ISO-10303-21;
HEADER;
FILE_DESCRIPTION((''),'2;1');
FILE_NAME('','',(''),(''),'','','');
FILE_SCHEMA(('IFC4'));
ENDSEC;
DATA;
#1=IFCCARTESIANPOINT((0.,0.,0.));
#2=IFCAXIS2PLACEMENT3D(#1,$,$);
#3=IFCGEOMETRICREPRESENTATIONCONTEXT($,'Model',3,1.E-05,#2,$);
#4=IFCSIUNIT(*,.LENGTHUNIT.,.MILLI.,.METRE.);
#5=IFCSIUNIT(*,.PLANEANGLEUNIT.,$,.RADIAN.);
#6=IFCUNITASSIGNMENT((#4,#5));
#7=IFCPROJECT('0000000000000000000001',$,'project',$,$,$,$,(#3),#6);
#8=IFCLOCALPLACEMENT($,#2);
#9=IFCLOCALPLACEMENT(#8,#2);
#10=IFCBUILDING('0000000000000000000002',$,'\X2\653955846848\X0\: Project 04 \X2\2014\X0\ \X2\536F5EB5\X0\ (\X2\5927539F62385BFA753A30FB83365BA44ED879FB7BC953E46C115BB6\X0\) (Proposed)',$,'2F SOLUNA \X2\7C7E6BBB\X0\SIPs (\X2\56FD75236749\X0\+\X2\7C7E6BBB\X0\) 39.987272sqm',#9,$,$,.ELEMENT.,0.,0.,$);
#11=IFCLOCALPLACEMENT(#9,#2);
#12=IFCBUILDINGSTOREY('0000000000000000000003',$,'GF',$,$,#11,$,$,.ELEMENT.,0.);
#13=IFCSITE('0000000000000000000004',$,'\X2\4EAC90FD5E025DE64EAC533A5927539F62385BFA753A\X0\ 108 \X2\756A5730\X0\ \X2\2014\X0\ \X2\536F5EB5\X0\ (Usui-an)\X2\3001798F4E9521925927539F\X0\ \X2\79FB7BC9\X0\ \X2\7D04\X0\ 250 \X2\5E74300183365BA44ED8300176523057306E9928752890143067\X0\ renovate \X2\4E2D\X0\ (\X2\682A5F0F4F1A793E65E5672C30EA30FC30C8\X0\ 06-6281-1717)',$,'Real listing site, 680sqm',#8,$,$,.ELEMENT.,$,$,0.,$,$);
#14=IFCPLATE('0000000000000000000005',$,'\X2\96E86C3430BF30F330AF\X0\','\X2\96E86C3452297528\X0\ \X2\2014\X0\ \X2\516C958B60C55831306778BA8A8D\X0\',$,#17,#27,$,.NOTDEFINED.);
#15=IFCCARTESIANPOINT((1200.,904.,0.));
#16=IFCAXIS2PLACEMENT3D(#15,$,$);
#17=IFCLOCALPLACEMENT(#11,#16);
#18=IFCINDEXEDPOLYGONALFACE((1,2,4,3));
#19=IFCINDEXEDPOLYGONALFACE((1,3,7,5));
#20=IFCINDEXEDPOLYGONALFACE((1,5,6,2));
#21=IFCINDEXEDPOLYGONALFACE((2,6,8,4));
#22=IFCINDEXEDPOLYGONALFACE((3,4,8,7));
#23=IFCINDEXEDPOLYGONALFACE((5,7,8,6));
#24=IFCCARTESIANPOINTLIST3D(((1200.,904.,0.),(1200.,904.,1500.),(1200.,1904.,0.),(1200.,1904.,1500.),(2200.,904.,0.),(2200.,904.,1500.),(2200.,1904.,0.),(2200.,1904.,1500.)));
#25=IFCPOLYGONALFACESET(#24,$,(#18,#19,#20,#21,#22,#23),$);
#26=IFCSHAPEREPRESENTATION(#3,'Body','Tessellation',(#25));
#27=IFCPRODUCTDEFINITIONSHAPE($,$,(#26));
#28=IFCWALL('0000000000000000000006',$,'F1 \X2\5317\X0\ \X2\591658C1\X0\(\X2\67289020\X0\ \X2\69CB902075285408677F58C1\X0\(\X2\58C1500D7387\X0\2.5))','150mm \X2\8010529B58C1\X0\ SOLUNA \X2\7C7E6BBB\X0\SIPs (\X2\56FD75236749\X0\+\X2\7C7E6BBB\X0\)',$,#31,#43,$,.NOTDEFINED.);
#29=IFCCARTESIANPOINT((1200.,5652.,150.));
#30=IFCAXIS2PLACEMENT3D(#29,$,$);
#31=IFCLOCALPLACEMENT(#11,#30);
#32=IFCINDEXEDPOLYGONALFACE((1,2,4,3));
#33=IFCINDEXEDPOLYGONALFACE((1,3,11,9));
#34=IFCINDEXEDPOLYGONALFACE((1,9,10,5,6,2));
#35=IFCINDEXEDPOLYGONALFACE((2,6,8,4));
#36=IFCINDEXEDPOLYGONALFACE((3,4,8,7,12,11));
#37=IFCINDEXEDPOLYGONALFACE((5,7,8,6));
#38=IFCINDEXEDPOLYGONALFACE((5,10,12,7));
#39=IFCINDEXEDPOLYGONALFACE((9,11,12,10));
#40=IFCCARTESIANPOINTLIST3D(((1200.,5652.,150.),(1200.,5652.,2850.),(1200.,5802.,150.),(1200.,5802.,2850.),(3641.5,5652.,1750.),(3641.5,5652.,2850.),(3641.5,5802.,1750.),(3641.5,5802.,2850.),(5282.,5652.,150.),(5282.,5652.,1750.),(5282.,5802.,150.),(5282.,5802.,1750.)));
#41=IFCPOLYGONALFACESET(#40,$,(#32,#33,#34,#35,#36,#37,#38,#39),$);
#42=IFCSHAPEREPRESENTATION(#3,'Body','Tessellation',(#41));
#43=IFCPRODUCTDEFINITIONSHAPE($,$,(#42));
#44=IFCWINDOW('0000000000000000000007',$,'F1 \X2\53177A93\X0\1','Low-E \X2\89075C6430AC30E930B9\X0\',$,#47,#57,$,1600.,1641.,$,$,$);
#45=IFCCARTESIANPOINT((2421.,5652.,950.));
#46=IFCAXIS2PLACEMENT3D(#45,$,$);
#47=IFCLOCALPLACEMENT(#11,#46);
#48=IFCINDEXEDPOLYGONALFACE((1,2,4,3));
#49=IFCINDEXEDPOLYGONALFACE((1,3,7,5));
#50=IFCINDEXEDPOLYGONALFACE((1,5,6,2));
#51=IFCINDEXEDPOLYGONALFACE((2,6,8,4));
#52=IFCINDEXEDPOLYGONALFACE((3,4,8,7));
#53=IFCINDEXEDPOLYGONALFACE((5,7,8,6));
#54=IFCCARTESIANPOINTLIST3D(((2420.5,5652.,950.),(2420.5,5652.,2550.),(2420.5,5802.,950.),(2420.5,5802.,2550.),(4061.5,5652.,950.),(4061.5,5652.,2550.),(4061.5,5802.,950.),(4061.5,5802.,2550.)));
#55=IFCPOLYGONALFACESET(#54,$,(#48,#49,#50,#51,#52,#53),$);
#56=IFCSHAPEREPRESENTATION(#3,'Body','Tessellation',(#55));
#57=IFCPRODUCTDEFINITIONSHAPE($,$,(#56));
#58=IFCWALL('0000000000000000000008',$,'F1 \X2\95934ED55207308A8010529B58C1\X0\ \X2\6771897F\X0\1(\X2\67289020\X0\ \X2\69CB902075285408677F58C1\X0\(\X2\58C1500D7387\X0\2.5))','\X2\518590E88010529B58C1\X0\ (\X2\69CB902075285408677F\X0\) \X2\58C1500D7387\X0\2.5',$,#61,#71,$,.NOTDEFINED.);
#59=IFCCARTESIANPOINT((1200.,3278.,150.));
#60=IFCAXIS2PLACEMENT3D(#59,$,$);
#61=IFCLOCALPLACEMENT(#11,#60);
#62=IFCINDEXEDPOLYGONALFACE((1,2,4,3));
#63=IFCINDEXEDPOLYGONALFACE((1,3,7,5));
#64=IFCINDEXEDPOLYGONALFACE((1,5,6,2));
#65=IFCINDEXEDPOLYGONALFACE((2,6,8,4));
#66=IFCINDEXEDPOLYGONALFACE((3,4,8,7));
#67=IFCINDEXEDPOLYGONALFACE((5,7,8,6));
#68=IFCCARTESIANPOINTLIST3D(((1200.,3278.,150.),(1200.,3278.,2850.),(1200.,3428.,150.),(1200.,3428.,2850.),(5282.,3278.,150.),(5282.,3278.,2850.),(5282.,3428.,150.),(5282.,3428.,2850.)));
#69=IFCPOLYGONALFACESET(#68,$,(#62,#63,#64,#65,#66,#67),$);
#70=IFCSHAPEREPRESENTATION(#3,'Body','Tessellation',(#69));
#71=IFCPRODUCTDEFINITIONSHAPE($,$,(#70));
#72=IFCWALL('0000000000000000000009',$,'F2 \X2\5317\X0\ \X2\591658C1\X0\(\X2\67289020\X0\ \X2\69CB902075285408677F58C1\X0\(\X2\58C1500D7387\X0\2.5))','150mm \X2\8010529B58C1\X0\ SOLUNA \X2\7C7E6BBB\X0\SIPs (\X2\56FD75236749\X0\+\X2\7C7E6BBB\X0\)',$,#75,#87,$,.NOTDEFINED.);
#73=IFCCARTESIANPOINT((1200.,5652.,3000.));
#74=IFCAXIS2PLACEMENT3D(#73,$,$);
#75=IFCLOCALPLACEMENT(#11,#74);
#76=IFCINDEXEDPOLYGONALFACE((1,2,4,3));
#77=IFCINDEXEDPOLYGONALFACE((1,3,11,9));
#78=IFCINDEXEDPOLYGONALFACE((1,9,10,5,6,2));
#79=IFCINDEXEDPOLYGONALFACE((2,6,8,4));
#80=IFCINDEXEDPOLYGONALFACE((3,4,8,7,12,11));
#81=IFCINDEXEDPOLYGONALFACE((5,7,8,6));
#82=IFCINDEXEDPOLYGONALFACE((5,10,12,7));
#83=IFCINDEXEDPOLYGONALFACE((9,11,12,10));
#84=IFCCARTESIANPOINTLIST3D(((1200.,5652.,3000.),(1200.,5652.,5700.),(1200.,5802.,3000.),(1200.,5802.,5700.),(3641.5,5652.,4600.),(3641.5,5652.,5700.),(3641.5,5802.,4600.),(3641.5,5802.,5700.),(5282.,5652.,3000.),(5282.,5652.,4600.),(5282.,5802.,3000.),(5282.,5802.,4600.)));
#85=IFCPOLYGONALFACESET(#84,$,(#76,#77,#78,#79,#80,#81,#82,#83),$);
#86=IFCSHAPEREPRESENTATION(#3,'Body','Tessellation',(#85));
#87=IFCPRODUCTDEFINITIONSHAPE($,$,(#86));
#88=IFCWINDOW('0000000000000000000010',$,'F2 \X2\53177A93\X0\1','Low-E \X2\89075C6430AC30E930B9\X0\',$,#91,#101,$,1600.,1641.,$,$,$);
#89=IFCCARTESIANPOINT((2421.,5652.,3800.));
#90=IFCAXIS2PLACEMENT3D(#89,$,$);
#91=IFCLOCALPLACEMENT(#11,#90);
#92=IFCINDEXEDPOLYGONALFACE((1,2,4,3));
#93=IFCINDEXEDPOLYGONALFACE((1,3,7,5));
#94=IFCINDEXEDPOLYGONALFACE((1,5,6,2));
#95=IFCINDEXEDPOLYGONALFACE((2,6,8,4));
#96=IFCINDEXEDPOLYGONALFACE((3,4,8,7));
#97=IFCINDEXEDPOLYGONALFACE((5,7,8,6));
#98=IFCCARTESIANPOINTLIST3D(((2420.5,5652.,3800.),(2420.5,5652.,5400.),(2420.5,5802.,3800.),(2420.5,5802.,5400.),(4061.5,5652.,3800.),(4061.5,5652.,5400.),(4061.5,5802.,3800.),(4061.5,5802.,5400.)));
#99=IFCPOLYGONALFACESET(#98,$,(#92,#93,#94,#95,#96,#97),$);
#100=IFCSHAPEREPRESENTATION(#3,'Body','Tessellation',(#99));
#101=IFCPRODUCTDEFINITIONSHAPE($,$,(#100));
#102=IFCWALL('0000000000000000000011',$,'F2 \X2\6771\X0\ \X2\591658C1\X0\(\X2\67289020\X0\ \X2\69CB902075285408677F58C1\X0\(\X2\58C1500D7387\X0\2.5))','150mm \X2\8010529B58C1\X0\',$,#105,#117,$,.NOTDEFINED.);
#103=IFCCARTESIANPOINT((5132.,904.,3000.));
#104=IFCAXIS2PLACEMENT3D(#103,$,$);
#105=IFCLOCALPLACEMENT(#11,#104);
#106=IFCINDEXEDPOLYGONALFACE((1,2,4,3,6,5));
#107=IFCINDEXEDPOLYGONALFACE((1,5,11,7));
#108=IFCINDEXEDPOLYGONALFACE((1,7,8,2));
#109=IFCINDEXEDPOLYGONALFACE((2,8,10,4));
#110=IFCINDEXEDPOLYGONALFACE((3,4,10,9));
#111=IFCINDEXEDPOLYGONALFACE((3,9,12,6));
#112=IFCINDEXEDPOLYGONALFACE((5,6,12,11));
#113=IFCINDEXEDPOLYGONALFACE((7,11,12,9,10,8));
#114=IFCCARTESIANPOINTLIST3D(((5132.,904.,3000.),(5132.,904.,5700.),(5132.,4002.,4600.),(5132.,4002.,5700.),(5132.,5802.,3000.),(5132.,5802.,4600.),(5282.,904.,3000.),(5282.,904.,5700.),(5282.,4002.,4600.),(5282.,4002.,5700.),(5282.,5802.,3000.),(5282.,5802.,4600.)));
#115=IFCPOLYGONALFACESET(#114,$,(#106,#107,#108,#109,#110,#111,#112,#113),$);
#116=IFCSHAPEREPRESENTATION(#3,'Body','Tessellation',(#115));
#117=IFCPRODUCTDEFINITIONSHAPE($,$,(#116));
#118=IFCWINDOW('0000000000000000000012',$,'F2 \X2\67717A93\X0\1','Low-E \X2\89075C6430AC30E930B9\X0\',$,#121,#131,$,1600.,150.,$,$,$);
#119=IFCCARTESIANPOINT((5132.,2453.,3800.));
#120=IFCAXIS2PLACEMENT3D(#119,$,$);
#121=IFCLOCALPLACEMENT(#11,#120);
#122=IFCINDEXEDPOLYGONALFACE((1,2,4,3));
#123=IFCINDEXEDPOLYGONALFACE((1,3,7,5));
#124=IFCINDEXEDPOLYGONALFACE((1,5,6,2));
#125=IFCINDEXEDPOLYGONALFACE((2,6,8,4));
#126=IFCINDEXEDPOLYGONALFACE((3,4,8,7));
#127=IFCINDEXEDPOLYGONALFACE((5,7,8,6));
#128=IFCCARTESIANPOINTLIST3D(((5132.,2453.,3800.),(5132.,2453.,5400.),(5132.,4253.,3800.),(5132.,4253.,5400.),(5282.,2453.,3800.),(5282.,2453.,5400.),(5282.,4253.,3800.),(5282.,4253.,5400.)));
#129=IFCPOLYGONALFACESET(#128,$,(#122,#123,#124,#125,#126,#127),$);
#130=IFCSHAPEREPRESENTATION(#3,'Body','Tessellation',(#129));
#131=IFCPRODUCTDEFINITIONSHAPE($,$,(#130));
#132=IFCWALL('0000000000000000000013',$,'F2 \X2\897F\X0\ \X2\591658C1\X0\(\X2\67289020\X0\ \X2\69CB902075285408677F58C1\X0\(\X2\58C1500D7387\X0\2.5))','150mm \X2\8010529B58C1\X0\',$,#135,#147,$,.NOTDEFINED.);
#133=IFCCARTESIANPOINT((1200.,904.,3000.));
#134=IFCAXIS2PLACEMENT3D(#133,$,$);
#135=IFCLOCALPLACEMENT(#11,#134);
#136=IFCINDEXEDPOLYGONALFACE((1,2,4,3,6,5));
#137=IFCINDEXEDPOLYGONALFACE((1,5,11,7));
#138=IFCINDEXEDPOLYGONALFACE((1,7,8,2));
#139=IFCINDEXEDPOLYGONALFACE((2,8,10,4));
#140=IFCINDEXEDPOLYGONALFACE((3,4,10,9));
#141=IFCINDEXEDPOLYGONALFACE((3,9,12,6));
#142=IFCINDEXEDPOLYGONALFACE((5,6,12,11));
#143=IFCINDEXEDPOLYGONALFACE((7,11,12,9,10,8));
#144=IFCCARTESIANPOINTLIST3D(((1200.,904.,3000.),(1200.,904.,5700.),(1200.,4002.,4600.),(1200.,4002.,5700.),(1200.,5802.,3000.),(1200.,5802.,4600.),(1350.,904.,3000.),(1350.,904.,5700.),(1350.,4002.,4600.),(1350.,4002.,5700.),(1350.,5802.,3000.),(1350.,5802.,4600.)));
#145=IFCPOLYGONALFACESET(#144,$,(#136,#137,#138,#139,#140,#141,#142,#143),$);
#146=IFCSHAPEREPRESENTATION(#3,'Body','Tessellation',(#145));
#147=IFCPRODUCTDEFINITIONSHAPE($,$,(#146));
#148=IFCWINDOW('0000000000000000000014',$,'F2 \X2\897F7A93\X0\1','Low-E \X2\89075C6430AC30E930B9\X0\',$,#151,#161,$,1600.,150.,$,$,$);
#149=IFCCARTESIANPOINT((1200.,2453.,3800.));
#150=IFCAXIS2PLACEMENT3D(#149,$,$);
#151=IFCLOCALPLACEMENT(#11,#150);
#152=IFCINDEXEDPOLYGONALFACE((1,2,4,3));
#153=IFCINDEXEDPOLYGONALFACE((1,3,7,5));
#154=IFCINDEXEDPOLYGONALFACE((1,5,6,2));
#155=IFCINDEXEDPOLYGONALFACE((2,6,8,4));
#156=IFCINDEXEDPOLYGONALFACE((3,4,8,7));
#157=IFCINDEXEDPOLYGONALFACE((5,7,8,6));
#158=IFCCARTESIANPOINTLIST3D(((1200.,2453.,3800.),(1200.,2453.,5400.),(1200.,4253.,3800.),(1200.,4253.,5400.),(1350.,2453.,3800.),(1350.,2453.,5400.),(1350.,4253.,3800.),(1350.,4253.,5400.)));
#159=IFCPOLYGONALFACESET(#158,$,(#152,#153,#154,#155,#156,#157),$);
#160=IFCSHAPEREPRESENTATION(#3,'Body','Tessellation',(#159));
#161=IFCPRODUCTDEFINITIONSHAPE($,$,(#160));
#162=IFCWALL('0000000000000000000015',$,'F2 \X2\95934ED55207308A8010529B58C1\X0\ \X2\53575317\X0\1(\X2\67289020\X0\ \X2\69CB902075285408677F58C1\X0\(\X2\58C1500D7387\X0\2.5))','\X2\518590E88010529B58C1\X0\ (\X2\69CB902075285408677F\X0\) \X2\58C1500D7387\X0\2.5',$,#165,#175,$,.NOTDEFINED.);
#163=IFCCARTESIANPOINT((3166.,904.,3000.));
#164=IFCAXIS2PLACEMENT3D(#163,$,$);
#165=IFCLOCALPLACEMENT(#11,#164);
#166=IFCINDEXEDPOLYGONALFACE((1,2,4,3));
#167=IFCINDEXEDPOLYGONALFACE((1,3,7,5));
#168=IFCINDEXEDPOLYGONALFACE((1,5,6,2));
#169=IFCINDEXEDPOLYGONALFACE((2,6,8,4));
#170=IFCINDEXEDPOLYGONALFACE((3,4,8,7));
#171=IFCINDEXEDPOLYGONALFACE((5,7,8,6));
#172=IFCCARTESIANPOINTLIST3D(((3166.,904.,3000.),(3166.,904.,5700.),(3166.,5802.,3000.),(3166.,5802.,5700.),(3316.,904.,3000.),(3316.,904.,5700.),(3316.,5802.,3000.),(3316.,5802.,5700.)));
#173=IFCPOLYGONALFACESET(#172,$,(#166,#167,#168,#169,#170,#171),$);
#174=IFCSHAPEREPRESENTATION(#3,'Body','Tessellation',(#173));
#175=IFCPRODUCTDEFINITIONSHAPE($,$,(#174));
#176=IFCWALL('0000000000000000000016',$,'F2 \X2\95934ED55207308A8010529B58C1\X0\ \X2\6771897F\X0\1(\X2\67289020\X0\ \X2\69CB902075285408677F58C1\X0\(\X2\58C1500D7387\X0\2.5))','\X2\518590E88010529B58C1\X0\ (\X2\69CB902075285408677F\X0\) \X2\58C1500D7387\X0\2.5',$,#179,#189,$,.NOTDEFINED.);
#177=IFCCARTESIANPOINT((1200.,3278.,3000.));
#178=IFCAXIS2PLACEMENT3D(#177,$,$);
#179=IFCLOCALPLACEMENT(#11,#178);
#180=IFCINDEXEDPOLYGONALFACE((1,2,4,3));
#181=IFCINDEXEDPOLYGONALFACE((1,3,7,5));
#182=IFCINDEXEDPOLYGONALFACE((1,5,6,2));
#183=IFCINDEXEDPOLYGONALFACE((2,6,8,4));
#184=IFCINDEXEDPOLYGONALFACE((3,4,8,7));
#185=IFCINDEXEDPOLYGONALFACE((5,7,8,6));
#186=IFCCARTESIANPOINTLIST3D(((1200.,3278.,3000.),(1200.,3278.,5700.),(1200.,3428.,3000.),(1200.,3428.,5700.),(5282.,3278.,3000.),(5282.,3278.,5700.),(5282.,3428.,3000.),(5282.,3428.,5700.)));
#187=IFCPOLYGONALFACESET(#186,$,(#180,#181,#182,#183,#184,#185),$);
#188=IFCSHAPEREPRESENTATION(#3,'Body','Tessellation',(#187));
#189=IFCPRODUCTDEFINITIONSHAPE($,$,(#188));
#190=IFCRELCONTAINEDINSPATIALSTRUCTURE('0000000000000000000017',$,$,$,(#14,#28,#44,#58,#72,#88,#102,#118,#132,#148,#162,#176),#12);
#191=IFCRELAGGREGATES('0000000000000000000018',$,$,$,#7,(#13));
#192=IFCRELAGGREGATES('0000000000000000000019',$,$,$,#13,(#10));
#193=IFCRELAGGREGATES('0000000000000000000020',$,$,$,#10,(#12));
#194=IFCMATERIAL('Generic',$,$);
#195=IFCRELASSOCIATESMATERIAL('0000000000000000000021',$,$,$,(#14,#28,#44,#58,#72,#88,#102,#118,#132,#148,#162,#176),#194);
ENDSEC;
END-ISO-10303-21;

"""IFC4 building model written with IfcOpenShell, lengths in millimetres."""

from ifc_helpers import new_model, si_unit, frame, frame_2d, origin, place, context, project, spatial, rectangle, extrude, material, element, fill, save


model = new_model("IFC4")

# Units and contexts
model_context = context("Model", 3, precision=1e-05, world=origin())
ifc_project = project(units=[si_unit("LENGTHUNIT", "METRE", prefix="MILLI"), si_unit("PLANEANGLEUNIT", "RADIAN")], contexts=[model_context])

# Site, building, storey
site_placement = place(None, origin())
site = spatial("IfcSite", under=ifc_project, at=site_placement, Name="京都市左京区大原戸寺町 108 番地 — 卯庵 (Usui-an)、福井→大原 移築 約 250 年、茶室付、癒しの館用途で renovate 中 (株式会社日本リート 06-6281-1717)", ObjectType="Real listing site, 680sqm", CompositionType="ELEMENT", RefElevation=0.0)
building_placement = place(site_placement, origin())
building = spatial("IfcBuilding", under=site, at=building_placement, Name="改善案: Project 04 — 卯庵 (大原戸寺町・茶室付移築古民家) (Proposed)", ObjectType="2F SOLUNA 籾殻SIPs (国産杉+籾殻) 39.987272sqm", CompositionType="ELEMENT", ElevationOfRefHeight=0.0, ElevationOfTerrain=0.0)
storey_placement = place(building_placement, origin())
storey = spatial("IfcBuildingStorey", under=building, at=storey_placement, Name="GF", CompositionType="ELEMENT", Elevation=0.0)

# Plate
ifc_material_1 = material(Name="Generic")
plate_placement = place(storey_placement, frame((1200.0, 904.0, 0.0)))
element("IfcPlate", 1, at=plate_placement, inside=storey, material=ifc_material_1, Name="雨水タンク", Description="雨水利用 — 公開情報で確認", PredefinedType="NOTDEFINED", context=model_context, shape_type="SweptSolid", body=[
    extrude(rectangle(XDim=1000.0, YDim=1000.0, at=frame_2d((500.0, 500.0))), frame((1200.0, 904.0, 0.0)), (0.0, 0.0, 1.0), 1500.0),
])

# Wall, opening, window
wall_1_placement = place(storey_placement, frame((1200.0, 5652.0, 150.0)))
wall_1 = element("IfcWall", 2, at=wall_1_placement, inside=storey, material=ifc_material_1, Name="F1 北 外壁(木造 構造用合板壁(壁倍率2.5))", Description="150mm 耐力壁 SOLUNA 籾殻SIPs (国産杉+籾殻)", PredefinedType="NOTDEFINED", context=model_context, shape_type="SweptSolid", body=[
    extrude(rectangle(XDim=4082.0, YDim=150.0, at=frame_2d((2041.0, 75.0))), frame((1200.0, 5652.0, 150.0)), (0.0, 0.0, 1.0), 2700.0),
])
opening_1_placement = place(storey_placement, frame((2421.0, 5652.0, 950.0)))
opening_1 = element("IfcOpeningElement", 3, at=opening_1_placement, cuts=wall_1, PredefinedType="NOTDEFINED", context=model_context, shape_type="SweptSolid", body=[
    extrude(rectangle(XDim=1641.0, YDim=150.0, at=frame_2d((820.0, 75.0))), frame((2421.0, 5652.0, 950.0)), (0.0, 0.0, 1.0), 1600.0),
])
window_1_placement = place(storey_placement, frame((2421.0, 5652.0, 950.0)))
window_1 = element("IfcWindow", 4, at=window_1_placement, inside=storey, material=ifc_material_1, Name="F1 北窓1", Description="Low-E 複層ガラス", OverallHeight=1600.0, OverallWidth=1641.0, context=model_context, shape_type="SweptSolid", body=[
    extrude(rectangle(XDim=1641.0, YDim=150.0, at=frame_2d((820.0, 75.0))), frame((2421.0, 5652.0, 950.0)), (0.0, 0.0, 1.0), 1600.0),
])
fill(opening_1, window_1)

# Wall
wall_2_placement = place(storey_placement, frame((1200.0, 3278.0, 150.0)))
element("IfcWall", 5, at=wall_2_placement, inside=storey, material=ifc_material_1, Name="F1 間仕切り耐力壁 東西1(木造 構造用合板壁(壁倍率2.5))", Description="内部耐力壁 (構造用合板) 壁倍率2.5", PredefinedType="NOTDEFINED", context=model_context, shape_type="SweptSolid", body=[
    extrude(rectangle(XDim=4082.0, YDim=150.0, at=frame_2d((2041.0, 75.0))), frame((1200.0, 3278.0, 150.0)), (0.0, 0.0, 1.0), 2700.0),
])

# Walls, openings, windows
wall_3_placement = place(storey_placement, frame((1200.0, 5652.0, 3000.0)))
wall_3 = element("IfcWall", 6, at=wall_3_placement, inside=storey, material=ifc_material_1, Name="F2 北 外壁(木造 構造用合板壁(壁倍率2.5))", Description="150mm 耐力壁 SOLUNA 籾殻SIPs (国産杉+籾殻)", PredefinedType="NOTDEFINED", context=model_context, shape_type="SweptSolid", body=[
    extrude(rectangle(XDim=4082.0, YDim=150.0, at=frame_2d((2041.0, 75.0))), frame((1200.0, 5652.0, 3000.0)), (0.0, 0.0, 1.0), 2700.0),
])
opening_2_placement = place(storey_placement, frame((2421.0, 5652.0, 3800.0)))
opening_2 = element("IfcOpeningElement", 7, at=opening_2_placement, cuts=wall_3, PredefinedType="NOTDEFINED", context=model_context, shape_type="SweptSolid", body=[
    extrude(rectangle(XDim=1641.0, YDim=150.0, at=frame_2d((820.0, 75.0))), frame((2421.0, 5652.0, 3800.0)), (0.0, 0.0, 1.0), 1600.0),
])
window_2_placement = place(storey_placement, frame((2421.0, 5652.0, 3800.0)))
window_2 = element("IfcWindow", 8, at=window_2_placement, inside=storey, material=ifc_material_1, Name="F2 北窓1", Description="Low-E 複層ガラス", OverallHeight=1600.0, OverallWidth=1641.0, context=model_context, shape_type="SweptSolid", body=[
    extrude(rectangle(XDim=1641.0, YDim=150.0, at=frame_2d((820.0, 75.0))), frame((2421.0, 5652.0, 3800.0)), (0.0, 0.0, 1.0), 1600.0),
])
fill(opening_2, window_2)
wall_4_placement = place(storey_placement, frame((5132.0, 904.0, 3000.0)))
wall_4 = element("IfcWall", 9, at=wall_4_placement, inside=storey, material=ifc_material_1, Name="F2 東 外壁(木造 構造用合板壁(壁倍率2.5))", Description="150mm 耐力壁", PredefinedType="NOTDEFINED", context=model_context, shape_type="SweptSolid", body=[
    extrude(rectangle(XDim=150.0, YDim=4898.0, at=frame_2d((75.0, 2449.0))), frame((5132.0, 904.0, 3000.0)), (0.0, 0.0, 1.0), 2700.0),
])
opening_3_placement = place(storey_placement, frame((5132.0, 2453.0, 3800.0)))
opening_3 = element("IfcOpeningElement", 10, at=opening_3_placement, cuts=wall_4, PredefinedType="NOTDEFINED", context=model_context, shape_type="SweptSolid", body=[
    extrude(rectangle(XDim=150.0, YDim=1800.0, at=frame_2d((75.0, 900.0))), frame((5132.0, 2453.0, 3800.0)), (0.0, 0.0, 1.0), 1600.0),
])
window_3_placement = place(storey_placement, frame((5132.0, 2453.0, 3800.0)))
window_3 = element("IfcWindow", 11, at=window_3_placement, inside=storey, material=ifc_material_1, Name="F2 東窓1", Description="Low-E 複層ガラス", OverallHeight=1600.0, OverallWidth=150.0, context=model_context, shape_type="SweptSolid", body=[
    extrude(rectangle(XDim=150.0, YDim=1800.0, at=frame_2d((75.0, 900.0))), frame((5132.0, 2453.0, 3800.0)), (0.0, 0.0, 1.0), 1600.0),
])
fill(opening_3, window_3)
wall_5_placement = place(storey_placement, frame((1200.0, 904.0, 3000.0)))
wall_5 = element("IfcWall", 12, at=wall_5_placement, inside=storey, material=ifc_material_1, Name="F2 西 外壁(木造 構造用合板壁(壁倍率2.5))", Description="150mm 耐力壁", PredefinedType="NOTDEFINED", context=model_context, shape_type="SweptSolid", body=[
    extrude(rectangle(XDim=150.0, YDim=4898.0, at=frame_2d((75.0, 2449.0))), frame((1200.0, 904.0, 3000.0)), (0.0, 0.0, 1.0), 2700.0),
])
opening_4_placement = place(storey_placement, frame((1200.0, 2453.0, 3800.0)))
opening_4 = element("IfcOpeningElement", 13, at=opening_4_placement, cuts=wall_5, PredefinedType="NOTDEFINED", context=model_context, shape_type="SweptSolid", body=[
    extrude(rectangle(XDim=150.0, YDim=1800.0, at=frame_2d((75.0, 900.0))), frame((1200.0, 2453.0, 3800.0)), (0.0, 0.0, 1.0), 1600.0),
])
window_4_placement = place(storey_placement, frame((1200.0, 2453.0, 3800.0)))
window_4 = element("IfcWindow", 14, at=window_4_placement, inside=storey, material=ifc_material_1, Name="F2 西窓1", Description="Low-E 複層ガラス", OverallHeight=1600.0, OverallWidth=150.0, context=model_context, shape_type="SweptSolid", body=[
    extrude(rectangle(XDim=150.0, YDim=1800.0, at=frame_2d((75.0, 900.0))), frame((1200.0, 2453.0, 3800.0)), (0.0, 0.0, 1.0), 1600.0),
])
fill(opening_4, window_4)

# Walls
wall_6_placement = place(storey_placement, frame((3166.0, 904.0, 3000.0)))
element("IfcWall", 15, at=wall_6_placement, inside=storey, material=ifc_material_1, Name="F2 間仕切り耐力壁 南北1(木造 構造用合板壁(壁倍率2.5))", Description="内部耐力壁 (構造用合板) 壁倍率2.5", PredefinedType="NOTDEFINED", context=model_context, shape_type="SweptSolid", body=[
    extrude(rectangle(XDim=150.0, YDim=4898.0, at=frame_2d((75.0, 2449.0))), frame((3166.0, 904.0, 3000.0)), (0.0, 0.0, 1.0), 2700.0),
])
wall_7_placement = place(storey_placement, frame((1200.0, 3278.0, 3000.0)))
element("IfcWall", 16, at=wall_7_placement, inside=storey, material=ifc_material_1, Name="F2 間仕切り耐力壁 東西1(木造 構造用合板壁(壁倍率2.5))", Description="内部耐力壁 (構造用合板) 壁倍率2.5", PredefinedType="NOTDEFINED", context=model_context, shape_type="SweptSolid", body=[
    extrude(rectangle(XDim=4082.0, YDim=150.0, at=frame_2d((2041.0, 75.0))), frame((1200.0, 3278.0, 3000.0)), (0.0, 0.0, 1.0), 2700.0),
])

save(model, "model.ifc")
